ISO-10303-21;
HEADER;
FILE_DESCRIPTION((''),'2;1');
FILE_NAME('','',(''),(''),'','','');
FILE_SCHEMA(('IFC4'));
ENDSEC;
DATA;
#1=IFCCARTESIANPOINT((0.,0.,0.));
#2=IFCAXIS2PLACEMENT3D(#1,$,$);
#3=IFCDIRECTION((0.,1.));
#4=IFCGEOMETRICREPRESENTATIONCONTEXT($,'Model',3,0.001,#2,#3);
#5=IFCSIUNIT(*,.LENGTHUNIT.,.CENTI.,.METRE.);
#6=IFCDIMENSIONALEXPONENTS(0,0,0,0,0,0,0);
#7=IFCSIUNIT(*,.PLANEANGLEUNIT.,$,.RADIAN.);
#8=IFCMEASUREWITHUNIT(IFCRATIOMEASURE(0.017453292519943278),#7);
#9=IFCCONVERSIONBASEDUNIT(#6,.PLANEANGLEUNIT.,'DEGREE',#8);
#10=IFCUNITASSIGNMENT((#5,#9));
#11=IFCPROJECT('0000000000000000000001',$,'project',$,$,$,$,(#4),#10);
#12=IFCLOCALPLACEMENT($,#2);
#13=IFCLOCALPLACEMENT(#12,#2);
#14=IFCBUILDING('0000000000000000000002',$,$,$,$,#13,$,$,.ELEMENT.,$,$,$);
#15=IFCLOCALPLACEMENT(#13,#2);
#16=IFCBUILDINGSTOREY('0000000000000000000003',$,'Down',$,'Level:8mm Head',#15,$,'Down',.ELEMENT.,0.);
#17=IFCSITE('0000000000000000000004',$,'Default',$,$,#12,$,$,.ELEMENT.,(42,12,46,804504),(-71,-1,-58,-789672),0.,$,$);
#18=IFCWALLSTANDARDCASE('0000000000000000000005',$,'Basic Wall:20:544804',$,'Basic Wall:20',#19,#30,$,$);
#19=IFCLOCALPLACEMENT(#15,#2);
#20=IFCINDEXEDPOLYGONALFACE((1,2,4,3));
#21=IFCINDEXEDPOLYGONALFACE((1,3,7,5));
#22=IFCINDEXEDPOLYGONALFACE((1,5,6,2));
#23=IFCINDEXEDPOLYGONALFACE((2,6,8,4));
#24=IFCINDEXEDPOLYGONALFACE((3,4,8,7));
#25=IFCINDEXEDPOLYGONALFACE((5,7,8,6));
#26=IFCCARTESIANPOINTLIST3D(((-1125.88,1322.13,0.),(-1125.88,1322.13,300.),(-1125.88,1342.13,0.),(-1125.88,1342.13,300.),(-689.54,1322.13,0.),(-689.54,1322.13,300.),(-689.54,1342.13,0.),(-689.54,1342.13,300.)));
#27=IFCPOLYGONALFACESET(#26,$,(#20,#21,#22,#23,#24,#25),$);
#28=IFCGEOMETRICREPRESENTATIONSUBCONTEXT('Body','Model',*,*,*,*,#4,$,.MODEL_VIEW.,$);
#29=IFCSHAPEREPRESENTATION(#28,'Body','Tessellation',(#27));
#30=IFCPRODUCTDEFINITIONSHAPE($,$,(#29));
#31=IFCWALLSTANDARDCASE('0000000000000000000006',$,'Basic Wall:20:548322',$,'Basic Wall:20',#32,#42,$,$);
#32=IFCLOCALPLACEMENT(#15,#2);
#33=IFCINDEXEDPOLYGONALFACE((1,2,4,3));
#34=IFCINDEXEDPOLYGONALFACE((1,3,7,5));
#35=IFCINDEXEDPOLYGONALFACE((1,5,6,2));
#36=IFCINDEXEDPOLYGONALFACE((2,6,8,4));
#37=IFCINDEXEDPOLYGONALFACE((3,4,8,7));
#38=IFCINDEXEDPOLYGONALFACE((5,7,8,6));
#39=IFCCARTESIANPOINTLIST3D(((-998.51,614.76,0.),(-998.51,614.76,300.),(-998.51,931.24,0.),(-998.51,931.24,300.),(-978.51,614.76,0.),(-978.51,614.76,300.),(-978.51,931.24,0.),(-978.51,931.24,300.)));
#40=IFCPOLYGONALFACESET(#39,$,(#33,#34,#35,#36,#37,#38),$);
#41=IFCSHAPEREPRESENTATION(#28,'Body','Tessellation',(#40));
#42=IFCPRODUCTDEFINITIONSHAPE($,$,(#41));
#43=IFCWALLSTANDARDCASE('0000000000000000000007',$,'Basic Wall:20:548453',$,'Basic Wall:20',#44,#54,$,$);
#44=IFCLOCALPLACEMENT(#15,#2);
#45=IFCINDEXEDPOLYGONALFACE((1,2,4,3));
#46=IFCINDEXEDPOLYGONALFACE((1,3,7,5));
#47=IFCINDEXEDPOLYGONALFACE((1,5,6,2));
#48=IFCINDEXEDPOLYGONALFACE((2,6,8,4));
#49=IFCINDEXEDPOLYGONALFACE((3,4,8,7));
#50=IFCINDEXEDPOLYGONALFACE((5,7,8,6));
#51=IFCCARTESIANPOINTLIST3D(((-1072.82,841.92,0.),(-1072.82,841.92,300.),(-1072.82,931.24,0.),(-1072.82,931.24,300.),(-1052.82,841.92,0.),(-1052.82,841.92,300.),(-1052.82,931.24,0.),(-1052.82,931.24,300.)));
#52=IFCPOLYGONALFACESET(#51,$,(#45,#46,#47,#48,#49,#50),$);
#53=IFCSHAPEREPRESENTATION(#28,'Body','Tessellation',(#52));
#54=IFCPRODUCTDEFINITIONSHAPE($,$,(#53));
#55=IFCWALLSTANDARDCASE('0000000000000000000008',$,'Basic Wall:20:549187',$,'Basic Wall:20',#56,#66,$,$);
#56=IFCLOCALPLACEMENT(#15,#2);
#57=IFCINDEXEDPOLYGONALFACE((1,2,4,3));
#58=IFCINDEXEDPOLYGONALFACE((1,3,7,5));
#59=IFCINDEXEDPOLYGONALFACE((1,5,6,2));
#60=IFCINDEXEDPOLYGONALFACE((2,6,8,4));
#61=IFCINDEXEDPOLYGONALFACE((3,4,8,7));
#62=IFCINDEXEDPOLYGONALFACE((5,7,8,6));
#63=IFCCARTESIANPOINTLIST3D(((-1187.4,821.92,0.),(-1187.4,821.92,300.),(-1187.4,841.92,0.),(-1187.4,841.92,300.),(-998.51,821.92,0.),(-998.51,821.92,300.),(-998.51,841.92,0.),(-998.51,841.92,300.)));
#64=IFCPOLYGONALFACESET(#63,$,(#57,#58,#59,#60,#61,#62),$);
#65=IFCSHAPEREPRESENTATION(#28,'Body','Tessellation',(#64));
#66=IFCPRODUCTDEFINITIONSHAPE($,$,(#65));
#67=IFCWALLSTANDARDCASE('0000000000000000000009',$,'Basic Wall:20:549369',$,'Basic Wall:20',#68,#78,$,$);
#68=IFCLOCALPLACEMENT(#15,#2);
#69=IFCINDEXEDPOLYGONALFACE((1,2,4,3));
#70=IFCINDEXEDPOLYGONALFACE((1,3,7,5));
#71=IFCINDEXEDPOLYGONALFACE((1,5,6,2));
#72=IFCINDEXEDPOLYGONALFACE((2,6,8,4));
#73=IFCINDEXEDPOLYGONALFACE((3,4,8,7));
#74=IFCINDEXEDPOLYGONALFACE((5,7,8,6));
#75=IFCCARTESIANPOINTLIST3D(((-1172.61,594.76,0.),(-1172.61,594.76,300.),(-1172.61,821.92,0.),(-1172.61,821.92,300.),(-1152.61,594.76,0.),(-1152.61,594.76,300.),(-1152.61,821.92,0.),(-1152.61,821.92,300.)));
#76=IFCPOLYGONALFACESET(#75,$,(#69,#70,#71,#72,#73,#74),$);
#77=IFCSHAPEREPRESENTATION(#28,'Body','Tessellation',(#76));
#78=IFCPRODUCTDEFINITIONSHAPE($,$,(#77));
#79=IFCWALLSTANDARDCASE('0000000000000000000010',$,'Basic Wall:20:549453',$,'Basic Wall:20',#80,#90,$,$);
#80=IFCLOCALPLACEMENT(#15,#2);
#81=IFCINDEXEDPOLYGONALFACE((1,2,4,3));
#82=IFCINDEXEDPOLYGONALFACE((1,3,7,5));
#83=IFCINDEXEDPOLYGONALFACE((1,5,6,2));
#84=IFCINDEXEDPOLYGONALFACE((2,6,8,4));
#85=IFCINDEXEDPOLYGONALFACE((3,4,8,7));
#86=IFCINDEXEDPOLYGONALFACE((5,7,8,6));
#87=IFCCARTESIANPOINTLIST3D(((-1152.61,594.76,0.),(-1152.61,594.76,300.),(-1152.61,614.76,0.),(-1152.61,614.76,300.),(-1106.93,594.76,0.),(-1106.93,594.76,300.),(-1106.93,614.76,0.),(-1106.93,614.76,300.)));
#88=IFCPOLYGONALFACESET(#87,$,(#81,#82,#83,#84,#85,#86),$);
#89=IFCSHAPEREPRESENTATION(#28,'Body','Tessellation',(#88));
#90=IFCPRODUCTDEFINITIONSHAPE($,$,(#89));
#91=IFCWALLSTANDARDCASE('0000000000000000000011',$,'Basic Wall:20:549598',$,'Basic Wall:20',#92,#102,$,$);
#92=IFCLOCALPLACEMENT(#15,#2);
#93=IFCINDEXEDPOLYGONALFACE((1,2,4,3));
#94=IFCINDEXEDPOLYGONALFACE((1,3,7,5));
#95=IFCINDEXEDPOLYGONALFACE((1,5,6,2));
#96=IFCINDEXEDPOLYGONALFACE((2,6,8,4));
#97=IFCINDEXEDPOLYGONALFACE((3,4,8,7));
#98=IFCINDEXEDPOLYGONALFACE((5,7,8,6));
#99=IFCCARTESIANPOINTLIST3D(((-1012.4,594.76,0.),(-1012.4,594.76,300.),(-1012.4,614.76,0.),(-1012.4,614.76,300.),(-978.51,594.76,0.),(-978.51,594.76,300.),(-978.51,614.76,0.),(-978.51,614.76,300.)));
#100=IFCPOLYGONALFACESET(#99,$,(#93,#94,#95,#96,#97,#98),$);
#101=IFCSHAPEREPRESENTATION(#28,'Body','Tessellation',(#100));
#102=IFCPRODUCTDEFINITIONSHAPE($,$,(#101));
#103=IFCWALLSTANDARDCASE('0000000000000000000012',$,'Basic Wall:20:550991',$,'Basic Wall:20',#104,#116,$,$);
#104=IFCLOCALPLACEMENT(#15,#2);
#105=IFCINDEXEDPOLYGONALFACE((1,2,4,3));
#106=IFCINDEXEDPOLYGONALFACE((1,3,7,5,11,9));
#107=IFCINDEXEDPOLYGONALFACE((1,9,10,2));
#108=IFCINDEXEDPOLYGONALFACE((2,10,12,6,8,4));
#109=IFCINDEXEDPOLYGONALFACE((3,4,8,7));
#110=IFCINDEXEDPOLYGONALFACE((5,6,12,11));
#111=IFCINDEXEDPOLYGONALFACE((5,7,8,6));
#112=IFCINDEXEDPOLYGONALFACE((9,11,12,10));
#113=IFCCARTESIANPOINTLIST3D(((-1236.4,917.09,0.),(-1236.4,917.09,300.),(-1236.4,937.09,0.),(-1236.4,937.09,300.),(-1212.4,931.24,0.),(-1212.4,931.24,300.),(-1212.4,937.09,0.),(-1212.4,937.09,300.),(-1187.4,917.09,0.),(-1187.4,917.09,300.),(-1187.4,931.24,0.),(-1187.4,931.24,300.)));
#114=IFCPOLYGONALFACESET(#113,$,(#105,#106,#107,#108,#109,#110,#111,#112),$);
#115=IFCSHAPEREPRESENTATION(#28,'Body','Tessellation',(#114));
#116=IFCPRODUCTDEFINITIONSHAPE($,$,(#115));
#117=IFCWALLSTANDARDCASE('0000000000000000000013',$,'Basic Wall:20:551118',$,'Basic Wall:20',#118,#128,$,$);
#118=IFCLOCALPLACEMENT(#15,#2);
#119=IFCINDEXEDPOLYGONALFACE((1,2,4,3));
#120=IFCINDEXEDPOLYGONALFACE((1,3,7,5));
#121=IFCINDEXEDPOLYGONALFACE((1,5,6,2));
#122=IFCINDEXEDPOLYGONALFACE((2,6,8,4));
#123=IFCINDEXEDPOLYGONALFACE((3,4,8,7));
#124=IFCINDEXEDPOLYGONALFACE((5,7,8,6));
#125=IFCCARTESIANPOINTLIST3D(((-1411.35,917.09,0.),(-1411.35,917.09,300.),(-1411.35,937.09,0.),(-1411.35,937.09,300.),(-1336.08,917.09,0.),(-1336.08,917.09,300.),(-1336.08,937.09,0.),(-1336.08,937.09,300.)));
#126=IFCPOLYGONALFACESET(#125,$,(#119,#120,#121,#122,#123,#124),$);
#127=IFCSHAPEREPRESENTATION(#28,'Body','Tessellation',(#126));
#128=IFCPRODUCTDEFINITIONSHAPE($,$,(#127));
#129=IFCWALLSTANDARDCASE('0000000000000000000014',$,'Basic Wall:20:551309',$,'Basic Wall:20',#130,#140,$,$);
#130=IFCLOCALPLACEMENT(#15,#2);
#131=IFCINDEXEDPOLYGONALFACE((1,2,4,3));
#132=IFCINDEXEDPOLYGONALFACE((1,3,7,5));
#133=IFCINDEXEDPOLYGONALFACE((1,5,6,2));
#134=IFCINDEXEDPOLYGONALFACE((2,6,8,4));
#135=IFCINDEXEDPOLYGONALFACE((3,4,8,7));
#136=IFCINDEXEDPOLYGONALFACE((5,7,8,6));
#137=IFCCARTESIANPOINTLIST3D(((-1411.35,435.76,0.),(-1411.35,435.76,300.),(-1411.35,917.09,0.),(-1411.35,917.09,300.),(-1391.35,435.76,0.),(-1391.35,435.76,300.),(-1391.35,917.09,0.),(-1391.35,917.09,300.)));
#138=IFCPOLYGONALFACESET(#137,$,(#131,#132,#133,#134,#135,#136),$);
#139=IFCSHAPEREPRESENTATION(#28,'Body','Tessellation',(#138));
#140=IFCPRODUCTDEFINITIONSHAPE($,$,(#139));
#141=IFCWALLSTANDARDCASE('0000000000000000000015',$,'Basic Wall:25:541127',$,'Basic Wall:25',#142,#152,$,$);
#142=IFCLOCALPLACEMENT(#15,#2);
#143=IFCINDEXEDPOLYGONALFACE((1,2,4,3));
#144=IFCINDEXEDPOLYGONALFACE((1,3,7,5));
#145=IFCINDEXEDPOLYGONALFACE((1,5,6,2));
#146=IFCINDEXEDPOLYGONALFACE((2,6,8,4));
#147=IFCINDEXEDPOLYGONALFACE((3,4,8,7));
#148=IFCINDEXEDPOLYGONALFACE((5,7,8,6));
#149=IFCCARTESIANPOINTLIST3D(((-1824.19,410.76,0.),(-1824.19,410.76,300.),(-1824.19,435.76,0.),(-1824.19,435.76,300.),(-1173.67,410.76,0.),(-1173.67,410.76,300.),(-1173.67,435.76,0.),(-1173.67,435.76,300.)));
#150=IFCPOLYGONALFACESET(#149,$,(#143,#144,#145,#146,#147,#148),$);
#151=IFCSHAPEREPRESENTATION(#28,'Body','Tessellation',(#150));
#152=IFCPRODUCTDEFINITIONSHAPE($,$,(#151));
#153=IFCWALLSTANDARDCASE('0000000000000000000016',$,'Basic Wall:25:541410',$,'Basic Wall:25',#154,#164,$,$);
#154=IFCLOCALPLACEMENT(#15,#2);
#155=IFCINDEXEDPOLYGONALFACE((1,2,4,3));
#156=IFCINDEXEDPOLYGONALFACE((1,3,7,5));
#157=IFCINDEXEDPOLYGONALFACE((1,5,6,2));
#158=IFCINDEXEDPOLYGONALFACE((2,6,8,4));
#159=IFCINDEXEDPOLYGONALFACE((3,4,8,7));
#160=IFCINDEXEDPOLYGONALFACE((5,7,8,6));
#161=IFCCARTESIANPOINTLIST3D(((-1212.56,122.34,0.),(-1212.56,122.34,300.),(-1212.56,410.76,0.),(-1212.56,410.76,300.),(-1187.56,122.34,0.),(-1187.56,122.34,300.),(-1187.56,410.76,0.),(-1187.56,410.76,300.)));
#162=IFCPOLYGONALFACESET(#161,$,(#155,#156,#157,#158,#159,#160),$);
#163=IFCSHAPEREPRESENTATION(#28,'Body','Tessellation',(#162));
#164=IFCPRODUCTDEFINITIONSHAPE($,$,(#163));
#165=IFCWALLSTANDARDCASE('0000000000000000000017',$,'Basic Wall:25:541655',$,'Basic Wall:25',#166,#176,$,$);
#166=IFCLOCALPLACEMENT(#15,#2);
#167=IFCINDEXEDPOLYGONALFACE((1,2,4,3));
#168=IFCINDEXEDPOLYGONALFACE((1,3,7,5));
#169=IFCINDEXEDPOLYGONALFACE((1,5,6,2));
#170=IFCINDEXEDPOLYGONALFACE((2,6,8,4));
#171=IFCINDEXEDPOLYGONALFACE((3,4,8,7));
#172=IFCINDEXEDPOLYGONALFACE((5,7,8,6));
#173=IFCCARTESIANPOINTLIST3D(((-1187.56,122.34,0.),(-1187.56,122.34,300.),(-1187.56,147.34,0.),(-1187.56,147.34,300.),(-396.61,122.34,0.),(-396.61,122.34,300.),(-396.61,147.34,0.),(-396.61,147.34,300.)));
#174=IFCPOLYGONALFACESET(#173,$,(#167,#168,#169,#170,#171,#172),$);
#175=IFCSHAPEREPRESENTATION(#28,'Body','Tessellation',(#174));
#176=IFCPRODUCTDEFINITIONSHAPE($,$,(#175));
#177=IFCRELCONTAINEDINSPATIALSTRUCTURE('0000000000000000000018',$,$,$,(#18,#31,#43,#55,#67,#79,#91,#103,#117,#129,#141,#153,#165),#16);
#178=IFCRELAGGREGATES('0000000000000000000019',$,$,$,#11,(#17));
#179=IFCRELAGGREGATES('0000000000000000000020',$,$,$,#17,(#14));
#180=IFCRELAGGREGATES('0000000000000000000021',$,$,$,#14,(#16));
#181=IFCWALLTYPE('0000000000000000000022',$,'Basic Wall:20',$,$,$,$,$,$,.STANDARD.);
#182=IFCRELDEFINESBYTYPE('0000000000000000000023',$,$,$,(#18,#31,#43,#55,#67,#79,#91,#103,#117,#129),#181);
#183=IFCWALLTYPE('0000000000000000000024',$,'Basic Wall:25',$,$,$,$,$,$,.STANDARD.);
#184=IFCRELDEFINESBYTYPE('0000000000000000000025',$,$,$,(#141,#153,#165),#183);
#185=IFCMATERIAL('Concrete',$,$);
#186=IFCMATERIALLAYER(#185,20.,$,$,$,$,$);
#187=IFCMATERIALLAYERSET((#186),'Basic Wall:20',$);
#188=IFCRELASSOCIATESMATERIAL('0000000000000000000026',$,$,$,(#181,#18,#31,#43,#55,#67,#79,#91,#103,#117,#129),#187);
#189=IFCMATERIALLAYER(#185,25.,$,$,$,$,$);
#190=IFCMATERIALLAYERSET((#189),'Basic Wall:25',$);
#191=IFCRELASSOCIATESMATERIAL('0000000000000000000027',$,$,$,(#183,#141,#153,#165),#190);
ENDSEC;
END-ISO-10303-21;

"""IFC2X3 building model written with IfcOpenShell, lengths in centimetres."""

from ifc_helpers import new_model, entity, si_unit, converted_unit, direction, frame, frame_2d, origin, place, context, subcontext, project, spatial, polyline, rectangle, extrude, clip, bounded_halfspace, material, layer, layer_set, layer_usage, type_object, element, save


model = new_model("IFC2X3")

# Units and contexts
model_context = context("Model", 3, precision=0.001, world=origin(), true_north=direction((0.0, 1.0)))
body_context = subcontext(model_context, "Body", "Model", "MODEL_VIEW")
ifc_project = project(units=[si_unit("LENGTHUNIT", "METRE", prefix="CENTI"), converted_unit("PLANEANGLEUNIT", "DEGREE", entity("IfcRatioMeasure", 0.017453292519943278), si_unit("PLANEANGLEUNIT", "RADIAN"), dimensions=[0, 0, 0, 0, 0, 0, 0])], contexts=[model_context])

# Site, building, storey
site_placement = place(None, origin())
site = spatial("IfcSite", under=ifc_project, at=site_placement, Name="Default", CompositionType="ELEMENT", RefLatitude=(42, 12, 46, 804504), RefLongitude=(-71, -1, -58, -789672), RefElevation=0.0)
building_placement = place(site_placement, origin())
building = spatial("IfcBuilding", under=site, at=building_placement, CompositionType="ELEMENT")
storey_placement = place(building_placement, origin())
storey = spatial("IfcBuildingStorey", under=building, at=storey_placement, Name="Down", ObjectType="Level:8mm Head", LongName="Down", CompositionType="ELEMENT", Elevation=0.0)

# Walls
ifc_material = material(Name="Concrete")
ifc_layer_1 = layer(ifc_material, 20.0)
ifc_layer_set_1 = layer_set([ifc_layer_1], Name="Basic Wall:20")
wall_type_1 = type_object("IfcWallType", Name="Basic Wall:20", PredefinedType="STANDARD", material=ifc_layer_set_1)
ifc_layer_usage_1 = layer_usage(ifc_layer_set_1, "AXIS2", "POSITIVE", -10.0)
wall_1_placement = place(storey_placement, frame((-1125.88, 1332.13, 0.0)))
element("IfcWallStandardCase", 1, at=wall_1_placement, inside=storey, type_object=wall_type_1, material=ifc_layer_usage_1, Name="Basic Wall:20:544804", ObjectType="Basic Wall:20", context=body_context, shape_type="SweptSolid", body=[
    extrude(rectangle(XDim=436.34, YDim=20.0, at=frame_2d((218.17, 0.0), x_axis=(-1.0, 0.0))), origin(), (0.0, 0.0, 1.0), 300.0),
])
ifc_layer_usage_2 = layer_usage(ifc_layer_set_1, "AXIS2", "NEGATIVE", 10.0)
wall_2_placement = place(storey_placement, frame((-988.51, 614.76, 0.0), z_axis=(0.0, 0.0, 1.0), x_axis=(0.0, 1.0, 0.0)))
element("IfcWallStandardCase", 2, at=wall_2_placement, inside=storey, type_object=wall_type_1, material=ifc_layer_usage_2, Name="Basic Wall:20:548322", ObjectType="Basic Wall:20", context=body_context, shape_type="SweptSolid", body=[
    extrude(rectangle(XDim=316.47, YDim=20.0, at=frame_2d((158.24, 0.0), x_axis=(-1.0, 0.0))), origin(), (0.0, 0.0, 1.0), 300.0),
])
ifc_layer_usage_3 = layer_usage(ifc_layer_set_1, "AXIS2", "NEGATIVE", 10.0)
wall_3_placement = place(storey_placement, frame((-1062.82, 931.24, 0.0), z_axis=(0.0, 0.0, 1.0), x_axis=(0.0, -1.0, 0.0)))
element("IfcWallStandardCase", 3, at=wall_3_placement, inside=storey, type_object=wall_type_1, material=ifc_layer_usage_3, Name="Basic Wall:20:548453", ObjectType="Basic Wall:20", context=body_context, shape_type="SweptSolid", body=[
    extrude(rectangle(XDim=89.32, YDim=20.0, at=frame_2d((44.66, 0.0), x_axis=(-1.0, 0.0))), origin(), (0.0, 0.0, 1.0), 300.0),
])
ifc_layer_usage_4 = layer_usage(ifc_layer_set_1, "AXIS2", "POSITIVE", -10.0)
wall_4_placement = place(storey_placement, frame((-1187.4, 831.92, 0.0)))
element("IfcWallStandardCase", 4, at=wall_4_placement, inside=storey, type_object=wall_type_1, material=ifc_layer_usage_4, Name="Basic Wall:20:549187", ObjectType="Basic Wall:20", context=body_context, shape_type="SweptSolid", body=[
    extrude(rectangle(XDim=188.89, YDim=20.0, at=frame_2d((94.45, 0.0), x_axis=(-1.0, 0.0))), origin(), (0.0, 0.0, 1.0), 300.0),
])
ifc_layer_usage_5 = layer_usage(ifc_layer_set_1, "AXIS2", "POSITIVE", -10.0)
wall_5_placement = place(storey_placement, frame((-1162.61, 821.92, 0.0), z_axis=(0.0, 0.0, 1.0), x_axis=(0.0, -1.0, 0.0)))
element("IfcWallStandardCase", 5, at=wall_5_placement, inside=storey, type_object=wall_type_1, material=ifc_layer_usage_5, Name="Basic Wall:20:549369", ObjectType="Basic Wall:20", context=body_context, shape_type="SweptSolid", body=[
    extrude(rectangle(XDim=227.16, YDim=20.0, at=frame_2d((113.58, 0.0), x_axis=(-1.0, 0.0))), origin(), (0.0, 0.0, 1.0), 300.0),
])
ifc_layer_usage_6 = layer_usage(ifc_layer_set_1, "AXIS2", "POSITIVE", -10.0)
wall_6_placement = place(storey_placement, frame((-1152.61, 604.76, 0.0)))
element("IfcWallStandardCase", 6, at=wall_6_placement, inside=storey, type_object=wall_type_1, material=ifc_layer_usage_6, Name="Basic Wall:20:549453", ObjectType="Basic Wall:20", context=body_context, shape_type="SweptSolid", body=[
    extrude(rectangle(XDim=45.68, YDim=20.0, at=frame_2d((22.84, 0.0), x_axis=(-1.0, 0.0))), origin(), (0.0, 0.0, 1.0), 300.0),
])
ifc_layer_usage_7 = layer_usage(ifc_layer_set_1, "AXIS2", "POSITIVE", -10.0)
wall_7_placement = place(storey_placement, frame((-1012.4, 604.76, 0.0)))
element("IfcWallStandardCase", 7, at=wall_7_placement, inside=storey, type_object=wall_type_1, material=ifc_layer_usage_7, Name="Basic Wall:20:549598", ObjectType="Basic Wall:20", context=body_context, shape_type="SweptSolid", body=[
    extrude(rectangle(XDim=33.89, YDim=20.0, at=frame_2d((16.95, 0.0), x_axis=(-1.0, 0.0))), origin(), (0.0, 0.0, 1.0), 300.0),
])
ifc_layer_usage_8 = layer_usage(ifc_layer_set_1, "AXIS2", "NEGATIVE", 10.0)
wall_8_placement = place(storey_placement, frame((-1187.4, 927.09, 0.0), z_axis=(0.0, 0.0, 1.0), x_axis=(-1.0, 0.0, 0.0)))
element("IfcWallStandardCase", 8, at=wall_8_placement, inside=storey, type_object=wall_type_1, material=ifc_layer_usage_8, Name="Basic Wall:20:550991", ObjectType="Basic Wall:20", context=body_context, shape_type="Clipping", body=[
    clip(clip(extrude(rectangle(XDim=49.0, YDim=20.0, at=frame_2d((24.5, 0.0), x_axis=(-1.0, 0.0))), origin(), (0.0, 0.0, 1.0), 300.0), bounded_halfspace(frame((25.0, -4.14, 0.0), z_axis=(0.0, 1.0, 0.0), x_axis=(-1.0, 0.0, 0.0)), True, frame((25.0, -4.14, 0.0), z_axis=(0.0, 1.0, 0.0), x_axis=(-1.0, 0.0, 0.0)), polyline([(0.0, 0.0), (25.0, 0.0), (25.0, 300.0), (0.0, 300.0), (0.0, 0.0)]))), bounded_halfspace(frame((25.0, -4.14, 300.0), z_axis=(1.0, 0.0, 0.0), x_axis=(0.0, 1.0, 0.0)), True, frame((25.0, -4.14, 300.0), z_axis=(1.0, 0.0, 0.0), x_axis=(0.0, 1.0, 0.0)), polyline([(0.0, 0.0), (-5.86, 0.0), (-5.86, -18.0), (-5.86, -300.0), (0.0, -300.0), (0.0, 0.0)]))),
])
ifc_layer_usage_9 = layer_usage(ifc_layer_set_1, "AXIS2", "POSITIVE", -10.0)
wall_9_placement = place(storey_placement, frame((-1336.08, 927.09, 0.0), z_axis=(0.0, 0.0, 1.0), x_axis=(-1.0, 0.0, 0.0)))
element("IfcWallStandardCase", 9, at=wall_9_placement, inside=storey, type_object=wall_type_1, material=ifc_layer_usage_9, Name="Basic Wall:20:551118", ObjectType="Basic Wall:20", context=body_context, shape_type="SweptSolid", body=[
    extrude(rectangle(XDim=75.28, YDim=20.0, at=frame_2d((37.64, 0.0), x_axis=(-1.0, 0.0))), origin(), (0.0, 0.0, 1.0), 300.0),
])
ifc_layer_usage_10 = layer_usage(ifc_layer_set_1, "AXIS2", "POSITIVE", -10.0)
wall_10_placement = place(storey_placement, frame((-1401.35, 917.09, 0.0), z_axis=(0.0, 0.0, 1.0), x_axis=(0.0, -1.0, 0.0)))
element("IfcWallStandardCase", 10, at=wall_10_placement, inside=storey, type_object=wall_type_1, material=ifc_layer_usage_10, Name="Basic Wall:20:551309", ObjectType="Basic Wall:20", context=body_context, shape_type="SweptSolid", body=[
    extrude(rectangle(XDim=481.33, YDim=20.0, at=frame_2d((240.67, 0.0), x_axis=(-1.0, 0.0))), origin(), (0.0, 0.0, 1.0), 300.0),
])
ifc_layer_2 = layer(ifc_material, 25.0)
ifc_layer_set_2 = layer_set([ifc_layer_2], Name="Basic Wall:25")
ifc_layer_usage_11 = layer_usage(ifc_layer_set_2, "AXIS2", "POSITIVE", -12.5)
wall_type_2 = type_object("IfcWallType", Name="Basic Wall:25", PredefinedType="STANDARD", material=ifc_layer_set_2)
wall_11_placement = place(storey_placement, frame((-1824.19, 423.26, 0.0)))
element("IfcWallStandardCase", 11, at=wall_11_placement, inside=storey, type_object=wall_type_2, material=ifc_layer_usage_11, Name="Basic Wall:25:541127", ObjectType="Basic Wall:25", context=body_context, shape_type="SweptSolid", body=[
    extrude(rectangle(XDim=650.53, YDim=25.0, at=frame_2d((325.26, 0.0), x_axis=(-1.0, 0.0))), origin(), (0.0, 0.0, 1.0), 300.0),
])
ifc_layer_usage_12 = layer_usage(ifc_layer_set_2, "AXIS2", "NEGATIVE", 12.5)
wall_12_placement = place(storey_placement, frame((-1200.06, 410.76, 0.0), z_axis=(0.0, 0.0, 1.0), x_axis=(0.0, -1.0, 0.0)))
element("IfcWallStandardCase", 12, at=wall_12_placement, inside=storey, type_object=wall_type_2, material=ifc_layer_usage_12, Name="Basic Wall:25:541410", ObjectType="Basic Wall:25", context=body_context, shape_type="SweptSolid", body=[
    extrude(rectangle(XDim=288.42, YDim=25.0, at=frame_2d((144.21, 0.0), x_axis=(-1.0, 0.0))), origin(), (0.0, 0.0, 1.0), 300.0),
])
ifc_layer_usage_13 = layer_usage(ifc_layer_set_2, "AXIS2", "POSITIVE", -12.5)
wall_13_placement = place(storey_placement, frame((-1187.56, 134.84, 0.0)))
element("IfcWallStandardCase", 13, at=wall_13_placement, inside=storey, type_object=wall_type_2, material=ifc_layer_usage_13, Name="Basic Wall:25:541655", ObjectType="Basic Wall:25", context=body_context, shape_type="SweptSolid", body=[
    extrude(rectangle(XDim=790.95, YDim=25.0, at=frame_2d((395.47, 0.0), x_axis=(-1.0, 0.0))), origin(), (0.0, 0.0, 1.0), 300.0),
])

save(model, "model.ifc")
